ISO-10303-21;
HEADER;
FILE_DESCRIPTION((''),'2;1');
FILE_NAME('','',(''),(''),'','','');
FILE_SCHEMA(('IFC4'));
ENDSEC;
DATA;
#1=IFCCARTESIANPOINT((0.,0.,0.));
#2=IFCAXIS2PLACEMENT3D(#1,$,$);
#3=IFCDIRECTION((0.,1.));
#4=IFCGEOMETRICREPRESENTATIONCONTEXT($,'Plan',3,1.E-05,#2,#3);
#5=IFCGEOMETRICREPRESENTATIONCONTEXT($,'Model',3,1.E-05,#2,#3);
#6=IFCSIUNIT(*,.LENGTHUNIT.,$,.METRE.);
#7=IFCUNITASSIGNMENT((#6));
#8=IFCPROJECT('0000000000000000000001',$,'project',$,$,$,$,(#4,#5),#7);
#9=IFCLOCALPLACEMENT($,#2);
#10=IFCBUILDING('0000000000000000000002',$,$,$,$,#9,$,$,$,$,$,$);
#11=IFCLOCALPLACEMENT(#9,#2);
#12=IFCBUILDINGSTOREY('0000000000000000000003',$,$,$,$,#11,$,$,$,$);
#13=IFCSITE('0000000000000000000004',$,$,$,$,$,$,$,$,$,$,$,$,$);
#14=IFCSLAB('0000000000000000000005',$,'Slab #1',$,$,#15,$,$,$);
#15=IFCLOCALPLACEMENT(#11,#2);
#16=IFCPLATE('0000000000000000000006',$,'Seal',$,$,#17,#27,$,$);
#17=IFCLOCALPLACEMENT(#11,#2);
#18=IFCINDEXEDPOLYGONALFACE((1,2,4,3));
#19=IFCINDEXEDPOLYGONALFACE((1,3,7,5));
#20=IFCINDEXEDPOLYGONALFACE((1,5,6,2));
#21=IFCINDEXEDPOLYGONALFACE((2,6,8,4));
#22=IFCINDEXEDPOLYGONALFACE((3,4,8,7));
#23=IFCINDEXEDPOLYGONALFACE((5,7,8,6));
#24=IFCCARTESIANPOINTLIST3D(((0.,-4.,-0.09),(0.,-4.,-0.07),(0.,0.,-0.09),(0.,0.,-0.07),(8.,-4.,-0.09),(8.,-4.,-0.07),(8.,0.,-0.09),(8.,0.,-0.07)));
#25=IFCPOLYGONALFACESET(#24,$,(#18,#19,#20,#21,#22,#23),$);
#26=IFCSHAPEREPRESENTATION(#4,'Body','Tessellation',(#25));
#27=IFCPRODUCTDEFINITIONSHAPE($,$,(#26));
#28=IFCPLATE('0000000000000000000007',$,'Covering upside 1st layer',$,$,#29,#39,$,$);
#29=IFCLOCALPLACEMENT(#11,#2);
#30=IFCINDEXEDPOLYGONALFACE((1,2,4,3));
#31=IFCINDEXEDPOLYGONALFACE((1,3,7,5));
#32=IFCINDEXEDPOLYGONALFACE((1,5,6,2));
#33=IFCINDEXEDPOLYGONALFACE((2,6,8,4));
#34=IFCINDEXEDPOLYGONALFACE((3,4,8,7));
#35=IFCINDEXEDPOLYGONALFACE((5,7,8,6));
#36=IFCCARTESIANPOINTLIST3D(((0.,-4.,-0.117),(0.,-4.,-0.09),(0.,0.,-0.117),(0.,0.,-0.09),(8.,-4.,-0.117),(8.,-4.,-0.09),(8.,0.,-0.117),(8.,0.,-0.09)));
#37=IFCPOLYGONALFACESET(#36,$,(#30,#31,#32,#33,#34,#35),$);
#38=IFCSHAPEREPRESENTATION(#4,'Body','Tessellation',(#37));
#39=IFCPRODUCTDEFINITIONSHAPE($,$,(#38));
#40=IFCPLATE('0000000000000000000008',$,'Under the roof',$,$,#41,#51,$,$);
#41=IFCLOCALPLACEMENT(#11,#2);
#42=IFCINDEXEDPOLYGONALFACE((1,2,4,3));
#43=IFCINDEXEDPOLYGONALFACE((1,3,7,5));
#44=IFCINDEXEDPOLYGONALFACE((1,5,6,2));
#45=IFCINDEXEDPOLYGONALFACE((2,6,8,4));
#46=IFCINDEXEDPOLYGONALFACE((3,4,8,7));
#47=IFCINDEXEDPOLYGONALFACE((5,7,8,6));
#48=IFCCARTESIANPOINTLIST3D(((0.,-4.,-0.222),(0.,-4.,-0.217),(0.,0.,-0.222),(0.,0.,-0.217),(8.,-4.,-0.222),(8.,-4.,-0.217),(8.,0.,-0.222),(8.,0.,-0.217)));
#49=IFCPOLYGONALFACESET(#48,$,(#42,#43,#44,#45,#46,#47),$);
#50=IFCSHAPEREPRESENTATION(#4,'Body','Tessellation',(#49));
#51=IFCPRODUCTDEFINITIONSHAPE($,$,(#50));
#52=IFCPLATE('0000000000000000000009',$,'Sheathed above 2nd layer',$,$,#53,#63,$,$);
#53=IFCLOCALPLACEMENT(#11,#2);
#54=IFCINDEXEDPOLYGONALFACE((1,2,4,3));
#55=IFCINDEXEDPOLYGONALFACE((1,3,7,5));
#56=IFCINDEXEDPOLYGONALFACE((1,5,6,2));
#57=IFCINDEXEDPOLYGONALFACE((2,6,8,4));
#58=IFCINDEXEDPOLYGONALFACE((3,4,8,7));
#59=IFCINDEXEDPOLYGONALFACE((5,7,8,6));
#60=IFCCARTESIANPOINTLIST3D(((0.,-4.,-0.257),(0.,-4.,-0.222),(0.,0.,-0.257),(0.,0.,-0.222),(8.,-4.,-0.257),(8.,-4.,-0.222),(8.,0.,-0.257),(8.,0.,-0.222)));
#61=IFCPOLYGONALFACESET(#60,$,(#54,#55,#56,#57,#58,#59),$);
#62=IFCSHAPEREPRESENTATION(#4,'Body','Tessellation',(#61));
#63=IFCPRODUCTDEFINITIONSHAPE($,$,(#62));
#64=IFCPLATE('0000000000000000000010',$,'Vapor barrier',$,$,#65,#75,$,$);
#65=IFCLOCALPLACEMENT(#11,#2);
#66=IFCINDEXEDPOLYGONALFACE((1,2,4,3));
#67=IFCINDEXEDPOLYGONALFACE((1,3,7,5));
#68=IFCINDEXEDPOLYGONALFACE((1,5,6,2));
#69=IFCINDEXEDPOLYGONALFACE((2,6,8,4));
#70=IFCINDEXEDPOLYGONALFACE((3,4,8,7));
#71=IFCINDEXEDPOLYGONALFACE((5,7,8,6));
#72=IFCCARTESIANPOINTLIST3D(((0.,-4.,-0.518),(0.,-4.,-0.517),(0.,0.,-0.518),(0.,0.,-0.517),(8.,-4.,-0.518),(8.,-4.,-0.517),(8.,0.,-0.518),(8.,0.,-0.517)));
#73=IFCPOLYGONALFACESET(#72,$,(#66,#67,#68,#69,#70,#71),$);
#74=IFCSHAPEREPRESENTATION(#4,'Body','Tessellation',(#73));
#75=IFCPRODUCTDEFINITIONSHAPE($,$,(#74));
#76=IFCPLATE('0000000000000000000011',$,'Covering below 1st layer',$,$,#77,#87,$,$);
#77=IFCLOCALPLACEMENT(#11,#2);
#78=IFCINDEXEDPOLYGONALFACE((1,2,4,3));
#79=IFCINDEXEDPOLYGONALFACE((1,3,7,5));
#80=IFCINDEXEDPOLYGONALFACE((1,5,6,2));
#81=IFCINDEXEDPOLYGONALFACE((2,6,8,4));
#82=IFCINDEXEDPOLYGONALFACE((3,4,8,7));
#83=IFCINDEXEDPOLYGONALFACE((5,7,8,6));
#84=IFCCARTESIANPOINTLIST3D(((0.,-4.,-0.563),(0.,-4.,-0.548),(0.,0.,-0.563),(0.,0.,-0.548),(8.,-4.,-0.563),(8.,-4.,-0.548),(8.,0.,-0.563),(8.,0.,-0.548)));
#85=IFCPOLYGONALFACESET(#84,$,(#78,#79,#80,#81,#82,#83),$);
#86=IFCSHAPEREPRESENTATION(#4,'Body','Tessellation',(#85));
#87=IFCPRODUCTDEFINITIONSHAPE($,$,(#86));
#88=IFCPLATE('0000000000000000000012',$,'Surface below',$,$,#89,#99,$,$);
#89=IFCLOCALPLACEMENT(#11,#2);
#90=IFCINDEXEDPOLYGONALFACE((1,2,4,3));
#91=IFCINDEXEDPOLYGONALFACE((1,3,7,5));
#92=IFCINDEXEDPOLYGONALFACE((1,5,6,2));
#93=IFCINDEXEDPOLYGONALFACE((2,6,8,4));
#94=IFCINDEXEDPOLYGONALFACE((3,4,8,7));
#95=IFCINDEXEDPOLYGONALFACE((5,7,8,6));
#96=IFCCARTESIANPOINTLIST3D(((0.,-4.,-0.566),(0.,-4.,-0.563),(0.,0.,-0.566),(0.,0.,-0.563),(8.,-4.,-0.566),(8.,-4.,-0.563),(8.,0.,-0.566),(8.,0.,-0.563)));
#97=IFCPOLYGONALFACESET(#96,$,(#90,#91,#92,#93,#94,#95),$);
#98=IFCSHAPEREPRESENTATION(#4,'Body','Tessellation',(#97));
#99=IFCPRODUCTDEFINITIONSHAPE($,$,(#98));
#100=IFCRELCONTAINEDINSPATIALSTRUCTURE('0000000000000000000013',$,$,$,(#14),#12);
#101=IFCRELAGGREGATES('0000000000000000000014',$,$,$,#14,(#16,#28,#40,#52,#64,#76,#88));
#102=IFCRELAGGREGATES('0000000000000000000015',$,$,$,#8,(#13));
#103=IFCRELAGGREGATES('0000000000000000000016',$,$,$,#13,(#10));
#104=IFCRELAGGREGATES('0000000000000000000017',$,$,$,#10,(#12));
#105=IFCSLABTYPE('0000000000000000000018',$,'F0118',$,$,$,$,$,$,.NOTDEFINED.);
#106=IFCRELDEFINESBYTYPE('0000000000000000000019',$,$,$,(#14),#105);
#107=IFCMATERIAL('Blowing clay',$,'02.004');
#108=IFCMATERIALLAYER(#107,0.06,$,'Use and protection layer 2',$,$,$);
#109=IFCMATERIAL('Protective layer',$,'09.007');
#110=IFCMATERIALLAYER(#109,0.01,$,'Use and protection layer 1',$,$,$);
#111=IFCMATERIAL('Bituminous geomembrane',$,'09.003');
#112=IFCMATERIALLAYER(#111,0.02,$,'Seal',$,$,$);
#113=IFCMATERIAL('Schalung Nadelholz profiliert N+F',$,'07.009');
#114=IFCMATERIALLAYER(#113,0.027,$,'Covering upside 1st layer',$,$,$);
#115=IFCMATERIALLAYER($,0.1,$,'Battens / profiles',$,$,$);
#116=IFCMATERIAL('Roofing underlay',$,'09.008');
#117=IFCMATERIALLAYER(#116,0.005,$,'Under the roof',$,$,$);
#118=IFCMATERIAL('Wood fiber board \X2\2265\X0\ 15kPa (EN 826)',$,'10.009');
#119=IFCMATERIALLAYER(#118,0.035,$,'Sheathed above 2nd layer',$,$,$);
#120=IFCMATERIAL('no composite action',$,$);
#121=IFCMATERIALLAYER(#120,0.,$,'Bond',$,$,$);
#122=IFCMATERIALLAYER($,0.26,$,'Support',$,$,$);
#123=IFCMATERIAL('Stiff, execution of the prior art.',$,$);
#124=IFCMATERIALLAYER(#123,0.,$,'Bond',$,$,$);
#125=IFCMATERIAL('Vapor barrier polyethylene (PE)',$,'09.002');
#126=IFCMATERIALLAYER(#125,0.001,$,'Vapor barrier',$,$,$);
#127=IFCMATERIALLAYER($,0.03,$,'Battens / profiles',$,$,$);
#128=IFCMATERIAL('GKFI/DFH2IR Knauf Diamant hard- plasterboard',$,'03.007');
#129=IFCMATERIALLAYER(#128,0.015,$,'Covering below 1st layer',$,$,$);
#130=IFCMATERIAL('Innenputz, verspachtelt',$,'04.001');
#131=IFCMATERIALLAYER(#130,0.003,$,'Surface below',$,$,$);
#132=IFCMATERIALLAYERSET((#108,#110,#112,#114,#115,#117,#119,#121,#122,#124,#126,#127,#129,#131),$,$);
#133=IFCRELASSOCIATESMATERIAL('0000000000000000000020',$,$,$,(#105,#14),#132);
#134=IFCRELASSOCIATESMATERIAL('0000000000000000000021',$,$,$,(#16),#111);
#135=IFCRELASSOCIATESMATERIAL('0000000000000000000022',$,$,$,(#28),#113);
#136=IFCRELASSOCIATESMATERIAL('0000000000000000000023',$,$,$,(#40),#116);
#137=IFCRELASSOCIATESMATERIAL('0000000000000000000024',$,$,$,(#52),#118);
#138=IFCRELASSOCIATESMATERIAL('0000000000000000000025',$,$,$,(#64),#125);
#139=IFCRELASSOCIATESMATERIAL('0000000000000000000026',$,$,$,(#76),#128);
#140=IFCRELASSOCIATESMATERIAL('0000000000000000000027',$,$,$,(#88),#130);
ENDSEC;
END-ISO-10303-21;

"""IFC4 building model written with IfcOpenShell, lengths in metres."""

from ifc_helpers import new_model, si_unit, direction, frame, frame_2d, origin, place, context, project, spatial, rectangle, extrude, material, layer, layer_set, type_object, element, aggregate, save


model = new_model("IFC4")

# Units and contexts
plan_context = context("Plan", 3, precision=1e-05, world=origin(), true_north=direction((0.0, 1.0)))
model_context = context("Model", 3, precision=1e-05, world=origin(), true_north=direction((0.0, 1.0)))
ifc_project = project(units=[si_unit("LENGTHUNIT", "METRE")], contexts=[plan_context, model_context])

# Site, building, storey
site = spatial("IfcSite", under=ifc_project)
building_placement = place(None, origin())
building = spatial("IfcBuilding", under=site, at=building_placement)
storey_placement = place(building_placement, origin())
storey = spatial("IfcBuildingStorey", under=building, at=storey_placement)

# Slab, plates
ifc_material_1 = material(Name="Blowing clay", Category="02.004")
ifc_layer_1 = layer(ifc_material_1, 0.06, Name="Use and protection layer 2")
ifc_material_2 = material(Name="Protective layer", Category="09.007")
ifc_layer_2 = layer(ifc_material_2, 0.01, Name="Use and protection layer 1")
ifc_material_3 = material(Name="Bituminous geomembrane", Category="09.003")
ifc_layer_3 = layer(ifc_material_3, 0.02, Name="Seal")
ifc_material_4 = material(Name="Schalung Nadelholz profiliert N+F", Category="07.009")
ifc_layer_4 = layer(ifc_material_4, 0.027, Name="Covering upside 1st layer")
ifc_layer_5 = layer(None, 0.1, Name="Battens / profiles")
ifc_material_5 = material(Name="Roofing underlay", Category="09.008")
ifc_layer_6 = layer(ifc_material_5, 0.005, Name="Under the roof")
ifc_material_6 = material(Name="Wood fiber board ≥ 15kPa (EN 826)", Category="10.009")
ifc_layer_7 = layer(ifc_material_6, 0.035, Name="Sheathed above 2nd layer")
ifc_material_7 = material(Name="no composite action")
ifc_layer_8 = layer(ifc_material_7, 0.0, Name="Bond")
ifc_layer_9 = layer(None, 0.26, Name="Support")
ifc_material_8 = material(Name="Stiff, execution of the prior art.")
ifc_layer_10 = layer(ifc_material_8, 0.0, Name="Bond")
ifc_material_9 = material(Name="Vapor barrier polyethylene (PE)", Category="09.002")
ifc_layer_11 = layer(ifc_material_9, 0.001, Name="Vapor barrier")
ifc_layer_12 = layer(None, 0.03, Name="Battens / profiles")
ifc_material_10 = material(Name="GKFI/DFH2IR Knauf Diamant hard- plasterboard", Category="03.007")
ifc_layer_13 = layer(ifc_material_10, 0.015, Name="Covering below 1st layer")
ifc_material_11 = material(Name="Innenputz, verspachtelt", Category="04.001")
ifc_layer_14 = layer(ifc_material_11, 0.003, Name="Surface below")
ifc_layer_set = layer_set([ifc_layer_1, ifc_layer_2, ifc_layer_3, ifc_layer_4, ifc_layer_5, ifc_layer_6, ifc_layer_7, ifc_layer_8, ifc_layer_9, ifc_layer_10, ifc_layer_11, ifc_layer_12, ifc_layer_13, ifc_layer_14])
slab_type = type_object("IfcSlabType", Name="F0118", PredefinedType="NOTDEFINED", material=ifc_layer_set)
slab_placement = place(None, frame((0.0, 0.0, 0.0), z_axis=(0.0, 0.0, -1.0), x_axis=(1.0, 0.0, 0.0)))
slab = element("IfcSlab", 1, at=slab_placement, inside=storey, type_object=slab_type, material=ifc_layer_set, Name="Slab #1")
plate_1_placement = place(slab_placement, origin())
plate_1 = element("IfcPlate", 2, at=plate_1_placement, material=ifc_material_3, Name="Seal", context=plan_context, shape_type="SweptSolid", body=[
    extrude(rectangle(XDim=8.0, YDim=4.0, at=frame_2d((4.0, 2.0), x_axis=(1.0, 0.0))), frame((0.0, 0.0, 0.07), z_axis=(0.0, 0.0, 1.0), x_axis=(1.0, 0.0, 0.0)), (0.0, 0.0, 1.0), 0.02),
])
plate_2_placement = place(slab_placement, origin())
plate_2 = element("IfcPlate", 3, at=plate_2_placement, material=ifc_material_4, Name="Covering upside 1st layer", context=plan_context, shape_type="SweptSolid", body=[
    extrude(rectangle(XDim=8.0, YDim=4.0, at=frame_2d((4.0, 2.0), x_axis=(1.0, 0.0))), frame((0.0, 0.0, 0.09), z_axis=(0.0, 0.0, 1.0), x_axis=(1.0, 0.0, 0.0)), (0.0, 0.0, 1.0), 0.027),
])
plate_3_placement = place(slab_placement, origin())
plate_3 = element("IfcPlate", 4, at=plate_3_placement, material=ifc_material_5, Name="Under the roof", context=plan_context, shape_type="SweptSolid", body=[
    extrude(rectangle(XDim=8.0, YDim=4.0, at=frame_2d((4.0, 2.0), x_axis=(1.0, 0.0))), frame((0.0, 0.0, 0.217), z_axis=(0.0, 0.0, 1.0), x_axis=(1.0, 0.0, 0.0)), (0.0, 0.0, 1.0), 0.005),
])
plate_4_placement = place(slab_placement, origin())
plate_4 = element("IfcPlate", 5, at=plate_4_placement, material=ifc_material_6, Name="Sheathed above 2nd layer", context=plan_context, shape_type="SweptSolid", body=[
    extrude(rectangle(XDim=8.0, YDim=4.0, at=frame_2d((4.0, 2.0), x_axis=(1.0, 0.0))), frame((0.0, 0.0, 0.222), z_axis=(0.0, 0.0, 1.0), x_axis=(1.0, 0.0, 0.0)), (0.0, 0.0, 1.0), 0.035),
])
plate_5_placement = place(slab_placement, origin())
plate_5 = element("IfcPlate", 6, at=plate_5_placement, material=ifc_material_9, Name="Vapor barrier", context=plan_context, shape_type="SweptSolid", body=[
    extrude(rectangle(XDim=8.0, YDim=4.0, at=frame_2d((4.0, 2.0), x_axis=(1.0, 0.0))), frame((0.0, 0.0, 0.517), z_axis=(0.0, 0.0, 1.0), x_axis=(1.0, 0.0, 0.0)), (0.0, 0.0, 1.0), 0.001),
])
plate_6_placement = place(slab_placement, origin())
plate_6 = element("IfcPlate", 7, at=plate_6_placement, material=ifc_material_10, Name="Covering below 1st layer", context=plan_context, shape_type="SweptSolid", body=[
    extrude(rectangle(XDim=8.0, YDim=4.0, at=frame_2d((4.0, 2.0), x_axis=(1.0, 0.0))), frame((0.0, 0.0, 0.548), z_axis=(0.0, 0.0, 1.0), x_axis=(1.0, 0.0, 0.0)), (0.0, 0.0, 1.0), 0.015),
])
plate_7_placement = place(slab_placement, origin())
plate_7 = element("IfcPlate", 8, at=plate_7_placement, material=ifc_material_11, Name="Surface below", context=plan_context, shape_type="SweptSolid", body=[
    extrude(rectangle(XDim=8.0, YDim=4.0, at=frame_2d((4.0, 2.0), x_axis=(1.0, 0.0))), frame((0.0, 0.0, 0.563), z_axis=(0.0, 0.0, 1.0), x_axis=(1.0, 0.0, 0.0)), (0.0, 0.0, 1.0), 0.003),
])
aggregate(slab, [plate_1, plate_2, plate_3, plate_4, plate_5, plate_6, plate_7])

save(model, "model.ifc")
